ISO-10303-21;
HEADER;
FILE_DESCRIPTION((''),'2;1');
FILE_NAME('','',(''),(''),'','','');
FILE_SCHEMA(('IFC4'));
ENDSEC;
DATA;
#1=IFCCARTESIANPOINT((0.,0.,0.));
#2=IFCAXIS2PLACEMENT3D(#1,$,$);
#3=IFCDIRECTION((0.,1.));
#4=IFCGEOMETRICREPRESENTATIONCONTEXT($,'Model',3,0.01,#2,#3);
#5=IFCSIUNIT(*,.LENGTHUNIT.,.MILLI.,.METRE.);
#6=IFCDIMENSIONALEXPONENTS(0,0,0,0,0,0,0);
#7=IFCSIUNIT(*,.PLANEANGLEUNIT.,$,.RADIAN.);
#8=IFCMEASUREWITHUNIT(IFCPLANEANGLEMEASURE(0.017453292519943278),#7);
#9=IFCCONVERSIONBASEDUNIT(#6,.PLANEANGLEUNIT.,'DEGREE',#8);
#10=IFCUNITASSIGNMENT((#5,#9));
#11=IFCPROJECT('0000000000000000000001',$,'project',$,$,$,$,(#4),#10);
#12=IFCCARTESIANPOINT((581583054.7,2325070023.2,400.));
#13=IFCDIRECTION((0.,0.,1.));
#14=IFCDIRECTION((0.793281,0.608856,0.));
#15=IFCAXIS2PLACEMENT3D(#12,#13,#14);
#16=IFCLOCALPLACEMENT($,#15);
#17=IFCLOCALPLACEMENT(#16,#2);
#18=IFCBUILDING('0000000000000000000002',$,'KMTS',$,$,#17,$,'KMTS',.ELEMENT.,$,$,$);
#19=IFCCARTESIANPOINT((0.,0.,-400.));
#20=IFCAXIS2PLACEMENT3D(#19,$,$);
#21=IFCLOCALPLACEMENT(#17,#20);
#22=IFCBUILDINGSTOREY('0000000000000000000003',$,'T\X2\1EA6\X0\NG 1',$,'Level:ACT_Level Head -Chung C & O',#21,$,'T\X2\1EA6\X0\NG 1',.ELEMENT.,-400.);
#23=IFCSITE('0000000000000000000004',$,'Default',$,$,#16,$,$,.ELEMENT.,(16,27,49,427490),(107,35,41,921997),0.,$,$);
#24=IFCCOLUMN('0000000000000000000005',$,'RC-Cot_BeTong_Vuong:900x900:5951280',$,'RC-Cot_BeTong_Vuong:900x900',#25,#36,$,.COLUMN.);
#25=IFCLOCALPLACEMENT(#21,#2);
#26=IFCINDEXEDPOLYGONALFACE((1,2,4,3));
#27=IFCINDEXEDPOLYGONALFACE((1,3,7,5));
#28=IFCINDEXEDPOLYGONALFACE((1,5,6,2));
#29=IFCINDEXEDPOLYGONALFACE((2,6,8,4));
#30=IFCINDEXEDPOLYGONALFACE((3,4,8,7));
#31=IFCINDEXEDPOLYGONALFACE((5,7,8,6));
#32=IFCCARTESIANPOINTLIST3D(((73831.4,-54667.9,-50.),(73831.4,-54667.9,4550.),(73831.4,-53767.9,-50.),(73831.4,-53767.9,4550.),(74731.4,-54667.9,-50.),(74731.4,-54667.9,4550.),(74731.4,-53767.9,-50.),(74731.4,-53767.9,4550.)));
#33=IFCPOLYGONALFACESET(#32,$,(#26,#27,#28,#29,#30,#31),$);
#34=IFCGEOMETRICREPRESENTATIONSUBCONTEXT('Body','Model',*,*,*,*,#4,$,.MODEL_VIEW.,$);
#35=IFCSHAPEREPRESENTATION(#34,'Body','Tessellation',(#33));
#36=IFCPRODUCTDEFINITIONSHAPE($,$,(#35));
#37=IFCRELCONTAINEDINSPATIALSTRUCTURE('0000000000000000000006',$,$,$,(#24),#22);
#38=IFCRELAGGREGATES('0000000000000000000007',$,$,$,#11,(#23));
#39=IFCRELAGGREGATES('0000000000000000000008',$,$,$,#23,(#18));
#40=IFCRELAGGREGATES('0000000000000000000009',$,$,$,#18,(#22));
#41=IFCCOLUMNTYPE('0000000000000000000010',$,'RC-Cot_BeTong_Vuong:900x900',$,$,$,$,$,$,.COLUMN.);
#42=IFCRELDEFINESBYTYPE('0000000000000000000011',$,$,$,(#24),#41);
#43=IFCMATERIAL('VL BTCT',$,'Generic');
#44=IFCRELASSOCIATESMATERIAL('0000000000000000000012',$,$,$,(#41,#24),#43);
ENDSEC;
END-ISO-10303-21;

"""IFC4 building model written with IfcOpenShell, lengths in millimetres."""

from ifc_helpers import new_model, entity, si_unit, converted_unit, direction, frame, origin, place, context, subcontext, project, spatial, indexed_curve, outline, extrude, source, transform, mapped, material, type_object, type_shapes, element, save


model = new_model("IFC4")

# Units and contexts
model_context = context("Model", 3, precision=0.01, world=origin(), true_north=direction((0.0, 1.0)))
body_context = subcontext(model_context, "Body", "Model", "MODEL_VIEW")
ifc_project = project(units=[si_unit("LENGTHUNIT", "METRE", prefix="MILLI"), converted_unit("PLANEANGLEUNIT", "DEGREE", entity("IfcPlaneAngleMeasure", 0.017453292519943278), si_unit("PLANEANGLEUNIT", "RADIAN"), dimensions=[0, 0, 0, 0, 0, 0, 0])], contexts=[model_context])

# Site, building, storey
site_placement = place(None, frame((581583054.7, 2325070023.2, 400.0), z_axis=(0.0, 0.0, 1.0), x_axis=(0.793281, 0.608856, 0.0)))
site = spatial("IfcSite", under=ifc_project, at=site_placement, Name="Default", CompositionType="ELEMENT", RefLatitude=(16, 27, 49, 427490), RefLongitude=(107, 35, 41, 921997), RefElevation=0.0)
building_placement = place(site_placement, origin())
building = spatial("IfcBuilding", under=site, at=building_placement, Name="KMTS", LongName="KMTS", CompositionType="ELEMENT")
storey_placement = place(building_placement, frame((0.0, 0.0, -400.0)))
storey = spatial("IfcBuildingStorey", under=building, at=storey_placement, Name="TẦNG 1", ObjectType="Level:ACT_Level Head -Chung C & O", LongName="TẦNG 1", CompositionType="ELEMENT", Elevation=-400.0)

# Column
ifc_material = material(Name="VL BTCT", Category="Generic")
column_type_1 = type_object("IfcColumnType", Name="RC-Cot_BeTong_Vuong:900x900", PredefinedType="COLUMN", material=ifc_material)
shared_shape_1 = source(origin(), body_context, "Body", "SweptSolid", [
    extrude(outline(indexed_curve([(-450.0, -450.0), (450.0, -450.0), (450.0, 450.0), (-450.0, 450.0), (-450.0, -450.0)], self_intersect=False)), frame((74281.4, -54217.9, -450.0), z_axis=(0.0, 0.0, 1.0), x_axis=(-1.0, 0.0, 0.0)), (0.0, 0.0, 1.0), 4600.0),
])
type_shapes(column_type_1, [shared_shape_1])
column_1_placement = place(storey_placement, frame((0.0, 0.0, 400.0)))
element("IfcColumn", 1, at=column_1_placement, inside=storey, type_object=column_type_1, material=ifc_material, Name="RC-Cot_BeTong_Vuong:900x900:5951280", ObjectType="RC-Cot_BeTong_Vuong:900x900", PredefinedType="COLUMN", context=body_context, shape_type="MappedRepresentation", body=[
    mapped(shared_shape_1, transform((0.0, 0.0, 0.0), scale=1.0)),
])

save(model, "model.ifc")
